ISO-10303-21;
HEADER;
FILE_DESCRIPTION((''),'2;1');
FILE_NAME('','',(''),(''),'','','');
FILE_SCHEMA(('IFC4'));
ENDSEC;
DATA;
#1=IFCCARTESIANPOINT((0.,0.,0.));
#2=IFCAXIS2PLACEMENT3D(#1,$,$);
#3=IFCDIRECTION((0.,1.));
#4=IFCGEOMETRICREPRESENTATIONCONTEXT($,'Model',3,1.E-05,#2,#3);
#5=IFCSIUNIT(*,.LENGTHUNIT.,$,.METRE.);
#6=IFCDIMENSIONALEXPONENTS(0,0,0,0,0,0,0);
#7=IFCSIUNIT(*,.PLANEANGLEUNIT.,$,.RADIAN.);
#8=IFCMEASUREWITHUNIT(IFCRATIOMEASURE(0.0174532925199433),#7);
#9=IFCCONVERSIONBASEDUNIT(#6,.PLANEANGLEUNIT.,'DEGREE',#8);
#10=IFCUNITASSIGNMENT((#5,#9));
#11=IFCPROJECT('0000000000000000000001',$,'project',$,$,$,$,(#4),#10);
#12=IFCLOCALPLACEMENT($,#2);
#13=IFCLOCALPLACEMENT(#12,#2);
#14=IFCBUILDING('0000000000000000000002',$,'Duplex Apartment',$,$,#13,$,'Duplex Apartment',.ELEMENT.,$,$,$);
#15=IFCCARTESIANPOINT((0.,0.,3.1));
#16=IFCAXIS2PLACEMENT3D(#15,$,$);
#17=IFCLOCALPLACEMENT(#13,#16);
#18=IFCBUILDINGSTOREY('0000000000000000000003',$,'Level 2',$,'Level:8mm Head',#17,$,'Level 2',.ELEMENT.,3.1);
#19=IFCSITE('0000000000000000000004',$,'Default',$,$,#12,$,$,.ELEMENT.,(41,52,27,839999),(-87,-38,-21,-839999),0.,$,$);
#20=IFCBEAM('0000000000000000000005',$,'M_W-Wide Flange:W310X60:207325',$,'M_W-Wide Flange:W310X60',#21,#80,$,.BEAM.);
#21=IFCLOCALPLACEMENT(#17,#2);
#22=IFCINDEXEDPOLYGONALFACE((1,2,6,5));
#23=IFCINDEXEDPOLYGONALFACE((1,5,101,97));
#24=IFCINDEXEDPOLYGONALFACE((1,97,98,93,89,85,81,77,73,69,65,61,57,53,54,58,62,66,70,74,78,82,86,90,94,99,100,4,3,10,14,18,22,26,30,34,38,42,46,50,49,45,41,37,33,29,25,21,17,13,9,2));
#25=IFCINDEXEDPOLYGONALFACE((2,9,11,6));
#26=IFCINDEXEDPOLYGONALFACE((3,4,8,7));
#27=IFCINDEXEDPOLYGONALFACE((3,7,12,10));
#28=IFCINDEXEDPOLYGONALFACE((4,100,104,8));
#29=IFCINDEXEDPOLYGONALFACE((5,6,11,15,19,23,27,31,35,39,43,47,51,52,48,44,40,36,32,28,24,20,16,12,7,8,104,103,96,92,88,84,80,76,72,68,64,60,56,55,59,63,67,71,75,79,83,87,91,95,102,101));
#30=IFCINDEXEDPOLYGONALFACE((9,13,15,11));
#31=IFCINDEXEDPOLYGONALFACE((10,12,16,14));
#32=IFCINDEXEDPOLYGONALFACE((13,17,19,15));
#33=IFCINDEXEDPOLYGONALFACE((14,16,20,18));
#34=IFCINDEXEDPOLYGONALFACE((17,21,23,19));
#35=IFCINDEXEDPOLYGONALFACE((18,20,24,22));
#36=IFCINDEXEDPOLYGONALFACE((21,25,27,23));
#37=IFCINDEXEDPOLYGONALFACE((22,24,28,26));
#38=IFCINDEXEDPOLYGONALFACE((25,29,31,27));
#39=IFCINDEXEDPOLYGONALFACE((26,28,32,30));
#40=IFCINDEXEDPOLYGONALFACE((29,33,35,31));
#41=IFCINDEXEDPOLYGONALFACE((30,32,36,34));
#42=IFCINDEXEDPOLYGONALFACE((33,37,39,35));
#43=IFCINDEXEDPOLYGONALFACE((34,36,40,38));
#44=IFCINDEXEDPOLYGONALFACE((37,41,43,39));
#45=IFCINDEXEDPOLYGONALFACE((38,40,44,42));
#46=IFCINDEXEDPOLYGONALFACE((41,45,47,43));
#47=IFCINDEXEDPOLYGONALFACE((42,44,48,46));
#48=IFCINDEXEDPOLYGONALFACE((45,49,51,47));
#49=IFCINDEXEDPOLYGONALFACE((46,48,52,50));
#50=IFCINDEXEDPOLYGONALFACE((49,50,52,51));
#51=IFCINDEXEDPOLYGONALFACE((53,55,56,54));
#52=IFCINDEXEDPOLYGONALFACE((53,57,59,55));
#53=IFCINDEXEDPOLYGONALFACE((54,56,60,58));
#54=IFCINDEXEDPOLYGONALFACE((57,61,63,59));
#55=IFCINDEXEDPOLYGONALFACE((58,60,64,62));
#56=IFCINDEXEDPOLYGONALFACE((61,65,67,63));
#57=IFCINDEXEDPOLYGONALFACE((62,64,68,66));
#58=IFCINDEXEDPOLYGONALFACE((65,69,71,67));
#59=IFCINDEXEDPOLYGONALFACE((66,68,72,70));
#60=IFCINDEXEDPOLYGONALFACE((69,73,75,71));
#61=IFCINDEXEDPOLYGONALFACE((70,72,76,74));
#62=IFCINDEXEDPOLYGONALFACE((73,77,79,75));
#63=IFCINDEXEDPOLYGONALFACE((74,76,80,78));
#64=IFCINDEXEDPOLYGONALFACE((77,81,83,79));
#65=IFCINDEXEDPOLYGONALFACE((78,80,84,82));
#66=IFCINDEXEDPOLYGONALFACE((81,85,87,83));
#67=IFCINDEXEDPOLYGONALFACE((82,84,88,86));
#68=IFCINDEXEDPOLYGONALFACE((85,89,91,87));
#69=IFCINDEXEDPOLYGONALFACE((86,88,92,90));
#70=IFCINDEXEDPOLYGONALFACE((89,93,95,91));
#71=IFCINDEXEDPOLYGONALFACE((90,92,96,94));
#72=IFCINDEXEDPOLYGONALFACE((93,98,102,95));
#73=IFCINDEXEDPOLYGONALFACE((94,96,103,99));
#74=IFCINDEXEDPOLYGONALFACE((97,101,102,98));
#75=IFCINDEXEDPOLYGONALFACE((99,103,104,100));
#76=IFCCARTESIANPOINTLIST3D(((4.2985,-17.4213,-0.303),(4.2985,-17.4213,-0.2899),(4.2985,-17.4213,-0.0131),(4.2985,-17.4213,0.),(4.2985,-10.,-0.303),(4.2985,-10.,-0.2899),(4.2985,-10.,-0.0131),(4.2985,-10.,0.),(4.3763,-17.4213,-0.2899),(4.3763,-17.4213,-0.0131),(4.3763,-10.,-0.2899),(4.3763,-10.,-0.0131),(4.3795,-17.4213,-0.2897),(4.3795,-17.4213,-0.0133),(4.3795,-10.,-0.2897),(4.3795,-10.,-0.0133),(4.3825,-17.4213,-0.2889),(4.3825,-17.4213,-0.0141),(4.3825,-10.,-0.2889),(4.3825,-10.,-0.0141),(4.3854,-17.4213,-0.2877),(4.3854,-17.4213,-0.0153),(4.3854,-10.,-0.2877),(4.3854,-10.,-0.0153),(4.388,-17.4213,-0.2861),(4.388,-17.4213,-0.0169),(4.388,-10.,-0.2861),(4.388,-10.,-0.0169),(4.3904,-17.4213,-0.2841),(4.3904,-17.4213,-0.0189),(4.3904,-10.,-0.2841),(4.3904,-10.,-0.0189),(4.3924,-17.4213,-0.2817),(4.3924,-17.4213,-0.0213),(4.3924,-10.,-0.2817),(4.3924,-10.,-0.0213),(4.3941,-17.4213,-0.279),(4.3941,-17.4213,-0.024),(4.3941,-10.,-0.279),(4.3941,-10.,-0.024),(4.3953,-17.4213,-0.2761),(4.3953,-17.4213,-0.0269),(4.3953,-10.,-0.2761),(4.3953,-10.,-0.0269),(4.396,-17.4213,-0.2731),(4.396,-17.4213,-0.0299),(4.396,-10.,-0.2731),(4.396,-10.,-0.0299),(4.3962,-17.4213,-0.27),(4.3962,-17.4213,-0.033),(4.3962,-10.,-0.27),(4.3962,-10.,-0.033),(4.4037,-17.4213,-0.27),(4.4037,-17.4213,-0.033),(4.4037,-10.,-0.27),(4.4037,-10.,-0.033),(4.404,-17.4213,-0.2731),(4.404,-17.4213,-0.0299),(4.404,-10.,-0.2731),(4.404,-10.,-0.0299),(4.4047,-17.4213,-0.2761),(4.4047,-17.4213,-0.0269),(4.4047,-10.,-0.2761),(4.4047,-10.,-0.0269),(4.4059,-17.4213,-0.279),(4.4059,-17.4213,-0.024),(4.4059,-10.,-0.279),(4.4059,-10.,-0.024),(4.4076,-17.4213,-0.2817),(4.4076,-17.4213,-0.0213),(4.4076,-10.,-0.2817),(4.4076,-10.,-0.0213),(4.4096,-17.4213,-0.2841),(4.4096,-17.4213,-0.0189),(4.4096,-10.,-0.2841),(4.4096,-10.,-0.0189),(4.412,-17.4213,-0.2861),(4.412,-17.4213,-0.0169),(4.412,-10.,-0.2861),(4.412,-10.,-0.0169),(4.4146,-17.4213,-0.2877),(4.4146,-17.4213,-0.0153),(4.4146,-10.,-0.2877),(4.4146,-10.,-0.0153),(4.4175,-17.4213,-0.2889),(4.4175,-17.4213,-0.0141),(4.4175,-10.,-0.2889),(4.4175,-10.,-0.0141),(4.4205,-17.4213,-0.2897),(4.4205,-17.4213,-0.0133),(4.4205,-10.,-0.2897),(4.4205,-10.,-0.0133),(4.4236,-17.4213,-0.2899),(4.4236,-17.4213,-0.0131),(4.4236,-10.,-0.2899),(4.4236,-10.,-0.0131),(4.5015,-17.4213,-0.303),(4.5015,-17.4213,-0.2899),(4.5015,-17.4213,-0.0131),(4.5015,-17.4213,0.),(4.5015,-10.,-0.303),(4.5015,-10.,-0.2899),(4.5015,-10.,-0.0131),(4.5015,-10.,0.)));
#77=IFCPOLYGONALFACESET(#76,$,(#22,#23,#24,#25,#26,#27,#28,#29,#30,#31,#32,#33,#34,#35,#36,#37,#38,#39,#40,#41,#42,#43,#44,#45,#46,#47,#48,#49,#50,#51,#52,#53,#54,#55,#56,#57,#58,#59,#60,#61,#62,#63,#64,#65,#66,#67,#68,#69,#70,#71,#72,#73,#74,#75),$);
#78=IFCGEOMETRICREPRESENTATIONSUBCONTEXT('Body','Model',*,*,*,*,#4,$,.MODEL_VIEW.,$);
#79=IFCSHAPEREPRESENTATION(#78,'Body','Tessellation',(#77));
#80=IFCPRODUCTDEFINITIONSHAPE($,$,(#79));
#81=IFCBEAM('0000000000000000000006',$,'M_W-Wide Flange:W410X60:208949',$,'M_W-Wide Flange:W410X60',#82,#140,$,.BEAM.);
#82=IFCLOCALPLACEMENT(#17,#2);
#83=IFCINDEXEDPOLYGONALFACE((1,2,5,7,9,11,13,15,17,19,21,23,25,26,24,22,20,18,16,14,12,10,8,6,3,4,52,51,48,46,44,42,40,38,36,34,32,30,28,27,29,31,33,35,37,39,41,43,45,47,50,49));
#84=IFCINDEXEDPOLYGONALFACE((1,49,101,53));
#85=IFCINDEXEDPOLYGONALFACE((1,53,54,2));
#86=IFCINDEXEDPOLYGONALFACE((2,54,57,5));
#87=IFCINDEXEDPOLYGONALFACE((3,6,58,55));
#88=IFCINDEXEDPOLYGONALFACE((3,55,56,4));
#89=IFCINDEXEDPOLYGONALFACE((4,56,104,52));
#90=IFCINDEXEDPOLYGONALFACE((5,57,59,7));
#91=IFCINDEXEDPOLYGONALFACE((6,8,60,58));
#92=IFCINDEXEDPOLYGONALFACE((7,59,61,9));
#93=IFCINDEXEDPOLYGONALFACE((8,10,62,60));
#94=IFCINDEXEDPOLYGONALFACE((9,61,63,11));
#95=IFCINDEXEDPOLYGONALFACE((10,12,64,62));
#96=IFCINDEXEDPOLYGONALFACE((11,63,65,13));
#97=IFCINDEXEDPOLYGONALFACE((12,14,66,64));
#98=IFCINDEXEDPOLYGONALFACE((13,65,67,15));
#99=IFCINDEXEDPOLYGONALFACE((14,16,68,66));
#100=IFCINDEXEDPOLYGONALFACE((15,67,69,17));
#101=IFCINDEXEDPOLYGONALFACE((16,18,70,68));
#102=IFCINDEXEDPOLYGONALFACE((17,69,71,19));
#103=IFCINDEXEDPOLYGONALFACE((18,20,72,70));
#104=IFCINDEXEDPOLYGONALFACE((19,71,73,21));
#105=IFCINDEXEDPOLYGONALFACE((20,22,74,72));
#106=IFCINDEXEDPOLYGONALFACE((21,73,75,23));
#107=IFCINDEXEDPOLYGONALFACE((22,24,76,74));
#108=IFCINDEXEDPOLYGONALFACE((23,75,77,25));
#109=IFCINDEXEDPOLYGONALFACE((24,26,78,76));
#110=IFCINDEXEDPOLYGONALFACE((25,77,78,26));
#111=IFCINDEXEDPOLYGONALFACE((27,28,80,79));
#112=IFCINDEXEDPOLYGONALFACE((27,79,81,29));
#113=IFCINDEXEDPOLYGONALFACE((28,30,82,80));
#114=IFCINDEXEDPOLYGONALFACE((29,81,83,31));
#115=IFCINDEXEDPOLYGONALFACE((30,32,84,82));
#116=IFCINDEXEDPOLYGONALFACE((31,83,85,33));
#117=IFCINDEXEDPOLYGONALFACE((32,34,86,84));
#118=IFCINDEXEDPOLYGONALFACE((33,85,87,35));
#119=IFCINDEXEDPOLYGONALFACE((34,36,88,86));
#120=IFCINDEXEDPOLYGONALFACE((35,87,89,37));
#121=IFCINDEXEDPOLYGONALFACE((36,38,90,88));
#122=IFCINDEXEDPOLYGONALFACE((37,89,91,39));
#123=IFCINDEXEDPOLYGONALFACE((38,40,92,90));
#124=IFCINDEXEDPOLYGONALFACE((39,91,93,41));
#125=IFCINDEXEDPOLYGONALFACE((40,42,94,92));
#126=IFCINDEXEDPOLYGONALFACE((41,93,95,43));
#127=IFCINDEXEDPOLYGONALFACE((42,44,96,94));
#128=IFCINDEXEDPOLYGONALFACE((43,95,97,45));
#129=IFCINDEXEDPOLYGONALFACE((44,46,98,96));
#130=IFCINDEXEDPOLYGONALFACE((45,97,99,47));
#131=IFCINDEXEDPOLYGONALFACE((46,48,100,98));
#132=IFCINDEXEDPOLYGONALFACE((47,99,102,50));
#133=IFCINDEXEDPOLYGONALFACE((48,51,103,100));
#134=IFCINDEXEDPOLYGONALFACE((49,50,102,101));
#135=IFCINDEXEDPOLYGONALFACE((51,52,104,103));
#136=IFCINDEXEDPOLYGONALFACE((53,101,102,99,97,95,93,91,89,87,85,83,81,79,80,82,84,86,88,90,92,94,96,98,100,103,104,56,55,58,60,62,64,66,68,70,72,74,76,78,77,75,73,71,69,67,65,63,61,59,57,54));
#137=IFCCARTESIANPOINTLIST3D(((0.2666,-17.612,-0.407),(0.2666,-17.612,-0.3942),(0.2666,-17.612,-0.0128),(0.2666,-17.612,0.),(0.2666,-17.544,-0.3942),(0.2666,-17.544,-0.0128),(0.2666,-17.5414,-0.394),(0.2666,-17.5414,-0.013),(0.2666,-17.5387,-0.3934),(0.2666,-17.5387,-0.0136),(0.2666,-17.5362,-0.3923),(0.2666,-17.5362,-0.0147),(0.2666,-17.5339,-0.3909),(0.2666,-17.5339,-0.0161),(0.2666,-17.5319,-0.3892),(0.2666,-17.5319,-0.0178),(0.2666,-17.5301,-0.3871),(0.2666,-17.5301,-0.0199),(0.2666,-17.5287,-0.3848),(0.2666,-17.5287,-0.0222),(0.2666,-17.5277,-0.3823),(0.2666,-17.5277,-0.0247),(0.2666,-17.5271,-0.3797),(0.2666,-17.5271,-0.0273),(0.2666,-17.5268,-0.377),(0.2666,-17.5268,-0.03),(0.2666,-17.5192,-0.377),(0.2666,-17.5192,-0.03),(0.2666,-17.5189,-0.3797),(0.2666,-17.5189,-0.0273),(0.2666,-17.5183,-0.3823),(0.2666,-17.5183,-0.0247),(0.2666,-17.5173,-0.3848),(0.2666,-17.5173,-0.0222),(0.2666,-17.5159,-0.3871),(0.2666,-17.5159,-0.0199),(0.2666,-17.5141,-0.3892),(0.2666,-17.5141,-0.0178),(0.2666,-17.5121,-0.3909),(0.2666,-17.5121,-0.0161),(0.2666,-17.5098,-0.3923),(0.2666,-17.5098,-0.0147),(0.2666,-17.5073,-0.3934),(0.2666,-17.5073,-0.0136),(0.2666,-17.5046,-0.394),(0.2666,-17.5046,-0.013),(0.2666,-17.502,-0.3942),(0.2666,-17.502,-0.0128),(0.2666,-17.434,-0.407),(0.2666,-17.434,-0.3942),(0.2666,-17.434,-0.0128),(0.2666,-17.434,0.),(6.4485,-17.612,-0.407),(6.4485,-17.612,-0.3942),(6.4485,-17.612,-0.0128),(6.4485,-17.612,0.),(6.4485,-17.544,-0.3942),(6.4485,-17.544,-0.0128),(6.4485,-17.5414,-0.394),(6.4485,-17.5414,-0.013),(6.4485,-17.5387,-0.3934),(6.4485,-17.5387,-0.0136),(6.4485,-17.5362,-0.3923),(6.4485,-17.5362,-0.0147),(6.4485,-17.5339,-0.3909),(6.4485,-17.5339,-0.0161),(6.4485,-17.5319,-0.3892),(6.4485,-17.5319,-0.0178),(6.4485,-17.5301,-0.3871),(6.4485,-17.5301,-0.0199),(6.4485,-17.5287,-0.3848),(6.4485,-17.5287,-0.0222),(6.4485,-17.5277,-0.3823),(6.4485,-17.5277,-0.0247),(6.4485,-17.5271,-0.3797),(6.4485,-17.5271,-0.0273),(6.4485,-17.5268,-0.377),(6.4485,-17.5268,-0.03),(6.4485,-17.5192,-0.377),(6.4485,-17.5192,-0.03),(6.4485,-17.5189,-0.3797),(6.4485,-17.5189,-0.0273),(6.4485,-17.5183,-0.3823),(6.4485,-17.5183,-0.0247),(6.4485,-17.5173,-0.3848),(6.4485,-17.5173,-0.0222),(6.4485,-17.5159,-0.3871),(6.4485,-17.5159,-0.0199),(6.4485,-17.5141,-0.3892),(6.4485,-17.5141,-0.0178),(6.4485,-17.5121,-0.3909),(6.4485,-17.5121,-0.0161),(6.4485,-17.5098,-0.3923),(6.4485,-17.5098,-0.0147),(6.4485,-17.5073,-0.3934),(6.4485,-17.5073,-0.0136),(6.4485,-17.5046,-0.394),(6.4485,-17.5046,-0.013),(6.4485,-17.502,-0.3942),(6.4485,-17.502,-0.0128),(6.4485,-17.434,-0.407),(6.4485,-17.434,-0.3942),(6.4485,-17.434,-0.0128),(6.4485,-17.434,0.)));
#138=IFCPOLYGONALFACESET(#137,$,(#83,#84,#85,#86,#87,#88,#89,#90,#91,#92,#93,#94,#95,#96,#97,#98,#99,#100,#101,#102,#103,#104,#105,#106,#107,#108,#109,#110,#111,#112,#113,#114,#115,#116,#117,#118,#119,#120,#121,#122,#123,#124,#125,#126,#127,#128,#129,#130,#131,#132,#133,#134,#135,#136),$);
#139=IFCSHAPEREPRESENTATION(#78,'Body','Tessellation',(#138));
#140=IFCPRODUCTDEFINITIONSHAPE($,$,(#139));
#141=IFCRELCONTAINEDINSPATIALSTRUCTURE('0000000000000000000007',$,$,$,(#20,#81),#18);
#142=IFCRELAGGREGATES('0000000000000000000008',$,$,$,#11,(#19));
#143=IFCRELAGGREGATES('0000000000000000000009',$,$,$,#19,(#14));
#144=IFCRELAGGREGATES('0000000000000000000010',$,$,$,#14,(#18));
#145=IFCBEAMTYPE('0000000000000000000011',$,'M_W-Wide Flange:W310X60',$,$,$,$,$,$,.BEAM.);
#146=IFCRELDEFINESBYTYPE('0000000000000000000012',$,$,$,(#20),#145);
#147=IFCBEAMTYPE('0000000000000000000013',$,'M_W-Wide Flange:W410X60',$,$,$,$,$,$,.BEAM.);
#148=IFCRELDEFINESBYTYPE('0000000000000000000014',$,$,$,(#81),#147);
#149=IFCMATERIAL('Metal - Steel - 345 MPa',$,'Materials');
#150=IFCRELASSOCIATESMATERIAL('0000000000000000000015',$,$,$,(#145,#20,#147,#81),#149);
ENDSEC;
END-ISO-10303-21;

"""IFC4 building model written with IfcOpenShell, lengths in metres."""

from ifc_helpers import new_model, entity, si_unit, converted_unit, direction, frame, origin, place, context, subcontext, project, spatial, indexed_curve, outline, extrude, source, transform, mapped, material, type_object, type_shapes, element, save


model = new_model("IFC4")

# Units and contexts
model_context = context("Model", 3, precision=1e-05, world=origin(), true_north=direction((0.0, 1.0)))
body_context = subcontext(model_context, "Body", "Model", "MODEL_VIEW")
ifc_project = project(units=[si_unit("LENGTHUNIT", "METRE"), converted_unit("PLANEANGLEUNIT", "DEGREE", entity("IfcRatioMeasure", 0.0174532925199433), si_unit("PLANEANGLEUNIT", "RADIAN"), dimensions=[0, 0, 0, 0, 0, 0, 0])], contexts=[model_context])

# Site, building, storey
site_placement = place(None, origin())
site = spatial("IfcSite", under=ifc_project, at=site_placement, Name="Default", CompositionType="ELEMENT", RefLatitude=(41, 52, 27, 839999), RefLongitude=(-87, -38, -21, -839999), RefElevation=0.0)
building_placement = place(site_placement, origin())
building = spatial("IfcBuilding", under=site, at=building_placement, Name="Duplex Apartment", LongName="Duplex Apartment", CompositionType="ELEMENT")
storey_placement = place(building_placement, frame((0.0, 0.0, 3.1)))
storey = spatial("IfcBuildingStorey", under=building, at=storey_placement, Name="Level 2", ObjectType="Level:8mm Head", LongName="Level 2", CompositionType="ELEMENT", Elevation=3.1)

# Beams
ifc_material_1 = material(Name="Metal - Steel - 345 MPa", Category="Materials")
beam_type_1 = type_object("IfcBeamType", Name="M_W-Wide Flange:W310X60", PredefinedType="BEAM", material=ifc_material_1)
shared_shape_1 = source(origin(), body_context, "Body", "SweptSolid", [
    extrude(outline(indexed_curve([(-0.1515, -0.1015), (-0.1384, -0.1015), (-0.1384, -0.0237), (-0.1382, -0.0205), (-0.1374, -0.0175), (-0.1362, -0.0146), (-0.1346, -0.012), (-0.1326, -0.0096), (-0.1302, -0.0076), (-0.1275, -0.0059), (-0.1246, -0.0047), (-0.1216, -0.004), (-0.1185, -0.0037), (0.1185, -0.0037), (0.1216, -0.004), (0.1246, -0.0047), (0.1275, -0.0059), (0.1302, -0.0076), (0.1326, -0.0096), (0.1346, -0.012), (0.1362, -0.0146), (0.1374, -0.0175), (0.1382, -0.0205), (0.1384, -0.0236), (0.1384, -0.1015), (0.1515, -0.1015), (0.1515, 0.1015), (0.1384, 0.1015), (0.1384, 0.0237), (0.1382, 0.0205), (0.1374, 0.0175), (0.1362, 0.0146), (0.1346, 0.012), (0.1326, 0.0096), (0.1302, 0.0076), (0.1275, 0.0059), (0.1246, 0.0047), (0.1216, 0.004), (0.1185, 0.0038), (-0.1185, 0.0038), (-0.1216, 0.004), (-0.1246, 0.0047), (-0.1275, 0.0059), (-0.1302, 0.0076), (-0.1326, 0.0096), (-0.1346, 0.012), (-0.1362, 0.0146), (-0.1374, 0.0175), (-0.1382, 0.0205), (-0.1384, 0.0237), (-0.1384, 0.1015), (-0.1515, 0.1015), (-0.1515, -0.1015)], self_intersect=False)), frame((-3.7615, 0.0, 0.0), z_axis=(1.0, 0.0, 0.0), x_axis=(0.0, 0.0, -1.0)), (0.0, 0.0, 1.0), 7.4213),
])
type_shapes(beam_type_1, [shared_shape_1])
beam_1_placement = place(storey_placement, frame((4.4, -13.7615, -0.1515), z_axis=(0.0, 0.0, 1.0), x_axis=(0.0, -1.0, 0.0)))
element("IfcBeam", 1, at=beam_1_placement, inside=storey, type_object=beam_type_1, material=ifc_material_1, Name="M_W-Wide Flange:W310X60:207325", ObjectType="M_W-Wide Flange:W310X60", PredefinedType="BEAM", context=body_context, shape_type="MappedRepresentation", body=[
    mapped(shared_shape_1, transform((0.0, 0.0, 0.0), scale=1.0)),
])
beam_type_2 = type_object("IfcBeamType", Name="M_W-Wide Flange:W410X60", PredefinedType="BEAM", material=ifc_material_1)
shared_shape_2 = source(origin(), body_context, "Body", "SweptSolid", [
    extrude(outline(indexed_curve([(-0.2035, -0.089), (-0.1907, -0.089), (-0.1907, -0.021), (-0.1905, -0.0184), (-0.1899, -0.0157), (-0.1888, -0.0132), (-0.1874, -0.0109), (-0.1857, -0.0089), (-0.1836, -0.0071), (-0.1813, -0.0057), (-0.1788, -0.0047), (-0.1762, -0.0041), (-0.1735, -0.0038), (0.1735, -0.0038), (0.1762, -0.0041), (0.1788, -0.0047), (0.1813, -0.0057), (0.1836, -0.0071), (0.1857, -0.0089), (0.1874, -0.0109), (0.1888, -0.0132), (0.1899, -0.0157), (0.1905, -0.0184), (0.1907, -0.021), (0.1907, -0.089), (0.2035, -0.089), (0.2035, 0.089), (0.1907, 0.089), (0.1907, 0.0211), (0.1905, 0.0184), (0.1899, 0.0157), (0.1888, 0.0132), (0.1874, 0.0109), (0.1857, 0.0089), (0.1836, 0.0071), (0.1813, 0.0057), (0.1788, 0.0047), (0.1762, 0.0041), (0.1735, 0.0039), (-0.1735, 0.0039), (-0.1762, 0.0041), (-0.1788, 0.0047), (-0.1813, 0.0057), (-0.1836, 0.0071), (-0.1857, 0.0089), (-0.1874, 0.0109), (-0.1888, 0.0132), (-0.1899, 0.0157), (-0.1905, 0.0184), (-0.1907, 0.0211), (-0.1907, 0.089), (-0.2035, 0.089), (-0.2035, -0.089)], self_intersect=False)), frame((-3.0909, 0.0, 0.0), z_axis=(1.0, 0.0, 0.0), x_axis=(0.0, 0.0, -1.0)), (0.0, 0.0, 1.0), 6.1819),
])
type_shapes(beam_type_2, [shared_shape_2])
beam_2_placement = place(storey_placement, frame((3.3576, -17.523, -0.2035)))
element("IfcBeam", 2, at=beam_2_placement, inside=storey, type_object=beam_type_2, material=ifc_material_1, Name="M_W-Wide Flange:W410X60:208949", ObjectType="M_W-Wide Flange:W410X60", PredefinedType="BEAM", context=body_context, shape_type="MappedRepresentation", body=[
    mapped(shared_shape_2, transform((0.0, 0.0, 0.0), scale=1.0)),
])

save(model, "model.ifc")
